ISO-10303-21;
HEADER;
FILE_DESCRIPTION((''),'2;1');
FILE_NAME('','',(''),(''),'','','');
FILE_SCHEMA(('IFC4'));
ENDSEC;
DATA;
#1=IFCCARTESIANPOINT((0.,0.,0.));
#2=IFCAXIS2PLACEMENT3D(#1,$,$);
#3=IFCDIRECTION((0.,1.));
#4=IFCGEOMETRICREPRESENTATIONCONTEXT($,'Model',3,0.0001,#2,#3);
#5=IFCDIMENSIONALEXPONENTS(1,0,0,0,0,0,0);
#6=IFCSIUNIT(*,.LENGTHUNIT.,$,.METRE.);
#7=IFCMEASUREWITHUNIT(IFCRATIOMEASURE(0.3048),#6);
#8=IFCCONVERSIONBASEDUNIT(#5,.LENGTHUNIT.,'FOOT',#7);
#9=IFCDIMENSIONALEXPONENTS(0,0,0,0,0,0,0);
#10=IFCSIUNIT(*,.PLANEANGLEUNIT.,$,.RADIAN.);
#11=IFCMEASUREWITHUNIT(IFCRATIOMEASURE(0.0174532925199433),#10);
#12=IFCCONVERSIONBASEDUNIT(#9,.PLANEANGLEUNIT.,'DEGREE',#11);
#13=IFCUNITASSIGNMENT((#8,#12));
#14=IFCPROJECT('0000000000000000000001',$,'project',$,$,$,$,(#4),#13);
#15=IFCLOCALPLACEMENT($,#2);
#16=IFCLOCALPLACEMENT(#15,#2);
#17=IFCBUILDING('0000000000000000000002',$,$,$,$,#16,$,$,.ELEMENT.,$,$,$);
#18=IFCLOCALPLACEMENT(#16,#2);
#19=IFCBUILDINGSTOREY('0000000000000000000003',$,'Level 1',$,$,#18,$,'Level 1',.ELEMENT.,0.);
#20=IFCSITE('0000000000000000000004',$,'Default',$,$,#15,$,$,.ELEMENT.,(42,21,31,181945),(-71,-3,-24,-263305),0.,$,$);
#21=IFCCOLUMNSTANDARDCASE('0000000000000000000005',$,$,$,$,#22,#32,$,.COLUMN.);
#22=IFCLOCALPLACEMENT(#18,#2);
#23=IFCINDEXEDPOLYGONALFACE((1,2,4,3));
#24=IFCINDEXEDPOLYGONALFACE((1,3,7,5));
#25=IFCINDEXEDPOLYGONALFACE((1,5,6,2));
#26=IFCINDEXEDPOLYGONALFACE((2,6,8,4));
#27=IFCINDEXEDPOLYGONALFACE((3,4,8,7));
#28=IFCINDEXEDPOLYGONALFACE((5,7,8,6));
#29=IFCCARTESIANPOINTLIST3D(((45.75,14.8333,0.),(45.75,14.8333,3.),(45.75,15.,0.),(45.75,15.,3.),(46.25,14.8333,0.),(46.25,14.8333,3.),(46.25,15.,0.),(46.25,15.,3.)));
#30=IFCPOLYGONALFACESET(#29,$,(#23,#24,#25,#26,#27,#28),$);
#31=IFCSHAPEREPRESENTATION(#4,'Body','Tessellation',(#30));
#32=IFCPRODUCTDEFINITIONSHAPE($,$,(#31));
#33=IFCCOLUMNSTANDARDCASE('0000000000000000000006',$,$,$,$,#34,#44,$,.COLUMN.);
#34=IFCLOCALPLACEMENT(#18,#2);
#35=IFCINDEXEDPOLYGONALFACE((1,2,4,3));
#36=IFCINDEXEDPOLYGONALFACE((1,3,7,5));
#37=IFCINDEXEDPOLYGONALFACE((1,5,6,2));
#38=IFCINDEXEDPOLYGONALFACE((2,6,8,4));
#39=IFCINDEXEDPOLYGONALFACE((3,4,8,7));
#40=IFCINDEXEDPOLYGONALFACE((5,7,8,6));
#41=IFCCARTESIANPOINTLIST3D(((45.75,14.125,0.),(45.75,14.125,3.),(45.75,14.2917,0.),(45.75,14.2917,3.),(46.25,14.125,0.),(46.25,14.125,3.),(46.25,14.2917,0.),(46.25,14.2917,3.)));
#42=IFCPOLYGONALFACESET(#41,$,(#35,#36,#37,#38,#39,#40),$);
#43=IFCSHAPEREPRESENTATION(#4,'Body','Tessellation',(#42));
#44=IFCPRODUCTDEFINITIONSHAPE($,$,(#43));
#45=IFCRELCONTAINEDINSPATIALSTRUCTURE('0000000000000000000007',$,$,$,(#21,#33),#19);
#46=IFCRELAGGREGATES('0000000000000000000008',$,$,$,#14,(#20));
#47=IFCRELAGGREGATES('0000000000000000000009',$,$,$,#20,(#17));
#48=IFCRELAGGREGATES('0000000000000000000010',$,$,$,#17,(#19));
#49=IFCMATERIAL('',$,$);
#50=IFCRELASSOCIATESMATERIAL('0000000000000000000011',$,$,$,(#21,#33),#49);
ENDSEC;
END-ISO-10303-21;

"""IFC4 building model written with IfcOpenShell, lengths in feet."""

from ifc_helpers import new_model, entity, si_unit, converted_unit, direction, frame, origin, place, context, project, spatial, rectangle, extrude, material, element, save


model = new_model("IFC4")

# Units and contexts
model_context = context("Model", 3, precision=0.0001, world=origin(), true_north=direction((0.0, 1.0)))
ifc_project = project(units=[converted_unit("LENGTHUNIT", "FOOT", entity("IfcRatioMeasure", 0.3048), si_unit("LENGTHUNIT", "METRE"), dimensions=[1, 0, 0, 0, 0, 0, 0]), converted_unit("PLANEANGLEUNIT", "DEGREE", entity("IfcRatioMeasure", 0.0174532925199433), si_unit("PLANEANGLEUNIT", "RADIAN"), dimensions=[0, 0, 0, 0, 0, 0, 0])], contexts=[model_context])

# Site, building, storey
site_placement = place(None, origin())
site = spatial("IfcSite", under=ifc_project, at=site_placement, Name="Default", CompositionType="ELEMENT", RefLatitude=(42, 21, 31, 181945), RefLongitude=(-71, -3, -24, -263305), RefElevation=0.0)
building_placement = place(site_placement, origin())
building = spatial("IfcBuilding", under=site, at=building_placement, CompositionType="ELEMENT")
storey_placement = place(building_placement, origin())
storey = spatial("IfcBuildingStorey", under=building, at=storey_placement, Name="Level 1", LongName="Level 1", CompositionType="ELEMENT", Elevation=0.0)

# Columns
placement_1 = place(storey_placement, frame((46.0, 46.25, 0.0), z_axis=(0.0, 0.0, 1.0), x_axis=(0.0, -1.0, 0.0)))
ifc_material_1 = material(Name="")
for number, where, z_axis, x_axis in (
    (1, (31.3334, 0.0, 0.0), (0.0, 0.0, 1.0), (1.0, 0.0, 0.0)),
    (2, (32.0417, 0.0, 0.0), (0.0, 0.0, 1.0), (1.0, 0.0, 0.0)),
):
    element("IfcColumnStandardCase", number, at=place(placement_1, frame(where, z_axis=z_axis, x_axis=x_axis)), inside=storey, material=ifc_material_1, PredefinedType="COLUMN", context=model_context, shape_type="SweptSolid", body=[
        extrude(rectangle(XDim=0.1667, YDim=0.5), origin(), (0.0, 0.0, 1.0), 3.0),
    ])

save(model, "model.ifc")
